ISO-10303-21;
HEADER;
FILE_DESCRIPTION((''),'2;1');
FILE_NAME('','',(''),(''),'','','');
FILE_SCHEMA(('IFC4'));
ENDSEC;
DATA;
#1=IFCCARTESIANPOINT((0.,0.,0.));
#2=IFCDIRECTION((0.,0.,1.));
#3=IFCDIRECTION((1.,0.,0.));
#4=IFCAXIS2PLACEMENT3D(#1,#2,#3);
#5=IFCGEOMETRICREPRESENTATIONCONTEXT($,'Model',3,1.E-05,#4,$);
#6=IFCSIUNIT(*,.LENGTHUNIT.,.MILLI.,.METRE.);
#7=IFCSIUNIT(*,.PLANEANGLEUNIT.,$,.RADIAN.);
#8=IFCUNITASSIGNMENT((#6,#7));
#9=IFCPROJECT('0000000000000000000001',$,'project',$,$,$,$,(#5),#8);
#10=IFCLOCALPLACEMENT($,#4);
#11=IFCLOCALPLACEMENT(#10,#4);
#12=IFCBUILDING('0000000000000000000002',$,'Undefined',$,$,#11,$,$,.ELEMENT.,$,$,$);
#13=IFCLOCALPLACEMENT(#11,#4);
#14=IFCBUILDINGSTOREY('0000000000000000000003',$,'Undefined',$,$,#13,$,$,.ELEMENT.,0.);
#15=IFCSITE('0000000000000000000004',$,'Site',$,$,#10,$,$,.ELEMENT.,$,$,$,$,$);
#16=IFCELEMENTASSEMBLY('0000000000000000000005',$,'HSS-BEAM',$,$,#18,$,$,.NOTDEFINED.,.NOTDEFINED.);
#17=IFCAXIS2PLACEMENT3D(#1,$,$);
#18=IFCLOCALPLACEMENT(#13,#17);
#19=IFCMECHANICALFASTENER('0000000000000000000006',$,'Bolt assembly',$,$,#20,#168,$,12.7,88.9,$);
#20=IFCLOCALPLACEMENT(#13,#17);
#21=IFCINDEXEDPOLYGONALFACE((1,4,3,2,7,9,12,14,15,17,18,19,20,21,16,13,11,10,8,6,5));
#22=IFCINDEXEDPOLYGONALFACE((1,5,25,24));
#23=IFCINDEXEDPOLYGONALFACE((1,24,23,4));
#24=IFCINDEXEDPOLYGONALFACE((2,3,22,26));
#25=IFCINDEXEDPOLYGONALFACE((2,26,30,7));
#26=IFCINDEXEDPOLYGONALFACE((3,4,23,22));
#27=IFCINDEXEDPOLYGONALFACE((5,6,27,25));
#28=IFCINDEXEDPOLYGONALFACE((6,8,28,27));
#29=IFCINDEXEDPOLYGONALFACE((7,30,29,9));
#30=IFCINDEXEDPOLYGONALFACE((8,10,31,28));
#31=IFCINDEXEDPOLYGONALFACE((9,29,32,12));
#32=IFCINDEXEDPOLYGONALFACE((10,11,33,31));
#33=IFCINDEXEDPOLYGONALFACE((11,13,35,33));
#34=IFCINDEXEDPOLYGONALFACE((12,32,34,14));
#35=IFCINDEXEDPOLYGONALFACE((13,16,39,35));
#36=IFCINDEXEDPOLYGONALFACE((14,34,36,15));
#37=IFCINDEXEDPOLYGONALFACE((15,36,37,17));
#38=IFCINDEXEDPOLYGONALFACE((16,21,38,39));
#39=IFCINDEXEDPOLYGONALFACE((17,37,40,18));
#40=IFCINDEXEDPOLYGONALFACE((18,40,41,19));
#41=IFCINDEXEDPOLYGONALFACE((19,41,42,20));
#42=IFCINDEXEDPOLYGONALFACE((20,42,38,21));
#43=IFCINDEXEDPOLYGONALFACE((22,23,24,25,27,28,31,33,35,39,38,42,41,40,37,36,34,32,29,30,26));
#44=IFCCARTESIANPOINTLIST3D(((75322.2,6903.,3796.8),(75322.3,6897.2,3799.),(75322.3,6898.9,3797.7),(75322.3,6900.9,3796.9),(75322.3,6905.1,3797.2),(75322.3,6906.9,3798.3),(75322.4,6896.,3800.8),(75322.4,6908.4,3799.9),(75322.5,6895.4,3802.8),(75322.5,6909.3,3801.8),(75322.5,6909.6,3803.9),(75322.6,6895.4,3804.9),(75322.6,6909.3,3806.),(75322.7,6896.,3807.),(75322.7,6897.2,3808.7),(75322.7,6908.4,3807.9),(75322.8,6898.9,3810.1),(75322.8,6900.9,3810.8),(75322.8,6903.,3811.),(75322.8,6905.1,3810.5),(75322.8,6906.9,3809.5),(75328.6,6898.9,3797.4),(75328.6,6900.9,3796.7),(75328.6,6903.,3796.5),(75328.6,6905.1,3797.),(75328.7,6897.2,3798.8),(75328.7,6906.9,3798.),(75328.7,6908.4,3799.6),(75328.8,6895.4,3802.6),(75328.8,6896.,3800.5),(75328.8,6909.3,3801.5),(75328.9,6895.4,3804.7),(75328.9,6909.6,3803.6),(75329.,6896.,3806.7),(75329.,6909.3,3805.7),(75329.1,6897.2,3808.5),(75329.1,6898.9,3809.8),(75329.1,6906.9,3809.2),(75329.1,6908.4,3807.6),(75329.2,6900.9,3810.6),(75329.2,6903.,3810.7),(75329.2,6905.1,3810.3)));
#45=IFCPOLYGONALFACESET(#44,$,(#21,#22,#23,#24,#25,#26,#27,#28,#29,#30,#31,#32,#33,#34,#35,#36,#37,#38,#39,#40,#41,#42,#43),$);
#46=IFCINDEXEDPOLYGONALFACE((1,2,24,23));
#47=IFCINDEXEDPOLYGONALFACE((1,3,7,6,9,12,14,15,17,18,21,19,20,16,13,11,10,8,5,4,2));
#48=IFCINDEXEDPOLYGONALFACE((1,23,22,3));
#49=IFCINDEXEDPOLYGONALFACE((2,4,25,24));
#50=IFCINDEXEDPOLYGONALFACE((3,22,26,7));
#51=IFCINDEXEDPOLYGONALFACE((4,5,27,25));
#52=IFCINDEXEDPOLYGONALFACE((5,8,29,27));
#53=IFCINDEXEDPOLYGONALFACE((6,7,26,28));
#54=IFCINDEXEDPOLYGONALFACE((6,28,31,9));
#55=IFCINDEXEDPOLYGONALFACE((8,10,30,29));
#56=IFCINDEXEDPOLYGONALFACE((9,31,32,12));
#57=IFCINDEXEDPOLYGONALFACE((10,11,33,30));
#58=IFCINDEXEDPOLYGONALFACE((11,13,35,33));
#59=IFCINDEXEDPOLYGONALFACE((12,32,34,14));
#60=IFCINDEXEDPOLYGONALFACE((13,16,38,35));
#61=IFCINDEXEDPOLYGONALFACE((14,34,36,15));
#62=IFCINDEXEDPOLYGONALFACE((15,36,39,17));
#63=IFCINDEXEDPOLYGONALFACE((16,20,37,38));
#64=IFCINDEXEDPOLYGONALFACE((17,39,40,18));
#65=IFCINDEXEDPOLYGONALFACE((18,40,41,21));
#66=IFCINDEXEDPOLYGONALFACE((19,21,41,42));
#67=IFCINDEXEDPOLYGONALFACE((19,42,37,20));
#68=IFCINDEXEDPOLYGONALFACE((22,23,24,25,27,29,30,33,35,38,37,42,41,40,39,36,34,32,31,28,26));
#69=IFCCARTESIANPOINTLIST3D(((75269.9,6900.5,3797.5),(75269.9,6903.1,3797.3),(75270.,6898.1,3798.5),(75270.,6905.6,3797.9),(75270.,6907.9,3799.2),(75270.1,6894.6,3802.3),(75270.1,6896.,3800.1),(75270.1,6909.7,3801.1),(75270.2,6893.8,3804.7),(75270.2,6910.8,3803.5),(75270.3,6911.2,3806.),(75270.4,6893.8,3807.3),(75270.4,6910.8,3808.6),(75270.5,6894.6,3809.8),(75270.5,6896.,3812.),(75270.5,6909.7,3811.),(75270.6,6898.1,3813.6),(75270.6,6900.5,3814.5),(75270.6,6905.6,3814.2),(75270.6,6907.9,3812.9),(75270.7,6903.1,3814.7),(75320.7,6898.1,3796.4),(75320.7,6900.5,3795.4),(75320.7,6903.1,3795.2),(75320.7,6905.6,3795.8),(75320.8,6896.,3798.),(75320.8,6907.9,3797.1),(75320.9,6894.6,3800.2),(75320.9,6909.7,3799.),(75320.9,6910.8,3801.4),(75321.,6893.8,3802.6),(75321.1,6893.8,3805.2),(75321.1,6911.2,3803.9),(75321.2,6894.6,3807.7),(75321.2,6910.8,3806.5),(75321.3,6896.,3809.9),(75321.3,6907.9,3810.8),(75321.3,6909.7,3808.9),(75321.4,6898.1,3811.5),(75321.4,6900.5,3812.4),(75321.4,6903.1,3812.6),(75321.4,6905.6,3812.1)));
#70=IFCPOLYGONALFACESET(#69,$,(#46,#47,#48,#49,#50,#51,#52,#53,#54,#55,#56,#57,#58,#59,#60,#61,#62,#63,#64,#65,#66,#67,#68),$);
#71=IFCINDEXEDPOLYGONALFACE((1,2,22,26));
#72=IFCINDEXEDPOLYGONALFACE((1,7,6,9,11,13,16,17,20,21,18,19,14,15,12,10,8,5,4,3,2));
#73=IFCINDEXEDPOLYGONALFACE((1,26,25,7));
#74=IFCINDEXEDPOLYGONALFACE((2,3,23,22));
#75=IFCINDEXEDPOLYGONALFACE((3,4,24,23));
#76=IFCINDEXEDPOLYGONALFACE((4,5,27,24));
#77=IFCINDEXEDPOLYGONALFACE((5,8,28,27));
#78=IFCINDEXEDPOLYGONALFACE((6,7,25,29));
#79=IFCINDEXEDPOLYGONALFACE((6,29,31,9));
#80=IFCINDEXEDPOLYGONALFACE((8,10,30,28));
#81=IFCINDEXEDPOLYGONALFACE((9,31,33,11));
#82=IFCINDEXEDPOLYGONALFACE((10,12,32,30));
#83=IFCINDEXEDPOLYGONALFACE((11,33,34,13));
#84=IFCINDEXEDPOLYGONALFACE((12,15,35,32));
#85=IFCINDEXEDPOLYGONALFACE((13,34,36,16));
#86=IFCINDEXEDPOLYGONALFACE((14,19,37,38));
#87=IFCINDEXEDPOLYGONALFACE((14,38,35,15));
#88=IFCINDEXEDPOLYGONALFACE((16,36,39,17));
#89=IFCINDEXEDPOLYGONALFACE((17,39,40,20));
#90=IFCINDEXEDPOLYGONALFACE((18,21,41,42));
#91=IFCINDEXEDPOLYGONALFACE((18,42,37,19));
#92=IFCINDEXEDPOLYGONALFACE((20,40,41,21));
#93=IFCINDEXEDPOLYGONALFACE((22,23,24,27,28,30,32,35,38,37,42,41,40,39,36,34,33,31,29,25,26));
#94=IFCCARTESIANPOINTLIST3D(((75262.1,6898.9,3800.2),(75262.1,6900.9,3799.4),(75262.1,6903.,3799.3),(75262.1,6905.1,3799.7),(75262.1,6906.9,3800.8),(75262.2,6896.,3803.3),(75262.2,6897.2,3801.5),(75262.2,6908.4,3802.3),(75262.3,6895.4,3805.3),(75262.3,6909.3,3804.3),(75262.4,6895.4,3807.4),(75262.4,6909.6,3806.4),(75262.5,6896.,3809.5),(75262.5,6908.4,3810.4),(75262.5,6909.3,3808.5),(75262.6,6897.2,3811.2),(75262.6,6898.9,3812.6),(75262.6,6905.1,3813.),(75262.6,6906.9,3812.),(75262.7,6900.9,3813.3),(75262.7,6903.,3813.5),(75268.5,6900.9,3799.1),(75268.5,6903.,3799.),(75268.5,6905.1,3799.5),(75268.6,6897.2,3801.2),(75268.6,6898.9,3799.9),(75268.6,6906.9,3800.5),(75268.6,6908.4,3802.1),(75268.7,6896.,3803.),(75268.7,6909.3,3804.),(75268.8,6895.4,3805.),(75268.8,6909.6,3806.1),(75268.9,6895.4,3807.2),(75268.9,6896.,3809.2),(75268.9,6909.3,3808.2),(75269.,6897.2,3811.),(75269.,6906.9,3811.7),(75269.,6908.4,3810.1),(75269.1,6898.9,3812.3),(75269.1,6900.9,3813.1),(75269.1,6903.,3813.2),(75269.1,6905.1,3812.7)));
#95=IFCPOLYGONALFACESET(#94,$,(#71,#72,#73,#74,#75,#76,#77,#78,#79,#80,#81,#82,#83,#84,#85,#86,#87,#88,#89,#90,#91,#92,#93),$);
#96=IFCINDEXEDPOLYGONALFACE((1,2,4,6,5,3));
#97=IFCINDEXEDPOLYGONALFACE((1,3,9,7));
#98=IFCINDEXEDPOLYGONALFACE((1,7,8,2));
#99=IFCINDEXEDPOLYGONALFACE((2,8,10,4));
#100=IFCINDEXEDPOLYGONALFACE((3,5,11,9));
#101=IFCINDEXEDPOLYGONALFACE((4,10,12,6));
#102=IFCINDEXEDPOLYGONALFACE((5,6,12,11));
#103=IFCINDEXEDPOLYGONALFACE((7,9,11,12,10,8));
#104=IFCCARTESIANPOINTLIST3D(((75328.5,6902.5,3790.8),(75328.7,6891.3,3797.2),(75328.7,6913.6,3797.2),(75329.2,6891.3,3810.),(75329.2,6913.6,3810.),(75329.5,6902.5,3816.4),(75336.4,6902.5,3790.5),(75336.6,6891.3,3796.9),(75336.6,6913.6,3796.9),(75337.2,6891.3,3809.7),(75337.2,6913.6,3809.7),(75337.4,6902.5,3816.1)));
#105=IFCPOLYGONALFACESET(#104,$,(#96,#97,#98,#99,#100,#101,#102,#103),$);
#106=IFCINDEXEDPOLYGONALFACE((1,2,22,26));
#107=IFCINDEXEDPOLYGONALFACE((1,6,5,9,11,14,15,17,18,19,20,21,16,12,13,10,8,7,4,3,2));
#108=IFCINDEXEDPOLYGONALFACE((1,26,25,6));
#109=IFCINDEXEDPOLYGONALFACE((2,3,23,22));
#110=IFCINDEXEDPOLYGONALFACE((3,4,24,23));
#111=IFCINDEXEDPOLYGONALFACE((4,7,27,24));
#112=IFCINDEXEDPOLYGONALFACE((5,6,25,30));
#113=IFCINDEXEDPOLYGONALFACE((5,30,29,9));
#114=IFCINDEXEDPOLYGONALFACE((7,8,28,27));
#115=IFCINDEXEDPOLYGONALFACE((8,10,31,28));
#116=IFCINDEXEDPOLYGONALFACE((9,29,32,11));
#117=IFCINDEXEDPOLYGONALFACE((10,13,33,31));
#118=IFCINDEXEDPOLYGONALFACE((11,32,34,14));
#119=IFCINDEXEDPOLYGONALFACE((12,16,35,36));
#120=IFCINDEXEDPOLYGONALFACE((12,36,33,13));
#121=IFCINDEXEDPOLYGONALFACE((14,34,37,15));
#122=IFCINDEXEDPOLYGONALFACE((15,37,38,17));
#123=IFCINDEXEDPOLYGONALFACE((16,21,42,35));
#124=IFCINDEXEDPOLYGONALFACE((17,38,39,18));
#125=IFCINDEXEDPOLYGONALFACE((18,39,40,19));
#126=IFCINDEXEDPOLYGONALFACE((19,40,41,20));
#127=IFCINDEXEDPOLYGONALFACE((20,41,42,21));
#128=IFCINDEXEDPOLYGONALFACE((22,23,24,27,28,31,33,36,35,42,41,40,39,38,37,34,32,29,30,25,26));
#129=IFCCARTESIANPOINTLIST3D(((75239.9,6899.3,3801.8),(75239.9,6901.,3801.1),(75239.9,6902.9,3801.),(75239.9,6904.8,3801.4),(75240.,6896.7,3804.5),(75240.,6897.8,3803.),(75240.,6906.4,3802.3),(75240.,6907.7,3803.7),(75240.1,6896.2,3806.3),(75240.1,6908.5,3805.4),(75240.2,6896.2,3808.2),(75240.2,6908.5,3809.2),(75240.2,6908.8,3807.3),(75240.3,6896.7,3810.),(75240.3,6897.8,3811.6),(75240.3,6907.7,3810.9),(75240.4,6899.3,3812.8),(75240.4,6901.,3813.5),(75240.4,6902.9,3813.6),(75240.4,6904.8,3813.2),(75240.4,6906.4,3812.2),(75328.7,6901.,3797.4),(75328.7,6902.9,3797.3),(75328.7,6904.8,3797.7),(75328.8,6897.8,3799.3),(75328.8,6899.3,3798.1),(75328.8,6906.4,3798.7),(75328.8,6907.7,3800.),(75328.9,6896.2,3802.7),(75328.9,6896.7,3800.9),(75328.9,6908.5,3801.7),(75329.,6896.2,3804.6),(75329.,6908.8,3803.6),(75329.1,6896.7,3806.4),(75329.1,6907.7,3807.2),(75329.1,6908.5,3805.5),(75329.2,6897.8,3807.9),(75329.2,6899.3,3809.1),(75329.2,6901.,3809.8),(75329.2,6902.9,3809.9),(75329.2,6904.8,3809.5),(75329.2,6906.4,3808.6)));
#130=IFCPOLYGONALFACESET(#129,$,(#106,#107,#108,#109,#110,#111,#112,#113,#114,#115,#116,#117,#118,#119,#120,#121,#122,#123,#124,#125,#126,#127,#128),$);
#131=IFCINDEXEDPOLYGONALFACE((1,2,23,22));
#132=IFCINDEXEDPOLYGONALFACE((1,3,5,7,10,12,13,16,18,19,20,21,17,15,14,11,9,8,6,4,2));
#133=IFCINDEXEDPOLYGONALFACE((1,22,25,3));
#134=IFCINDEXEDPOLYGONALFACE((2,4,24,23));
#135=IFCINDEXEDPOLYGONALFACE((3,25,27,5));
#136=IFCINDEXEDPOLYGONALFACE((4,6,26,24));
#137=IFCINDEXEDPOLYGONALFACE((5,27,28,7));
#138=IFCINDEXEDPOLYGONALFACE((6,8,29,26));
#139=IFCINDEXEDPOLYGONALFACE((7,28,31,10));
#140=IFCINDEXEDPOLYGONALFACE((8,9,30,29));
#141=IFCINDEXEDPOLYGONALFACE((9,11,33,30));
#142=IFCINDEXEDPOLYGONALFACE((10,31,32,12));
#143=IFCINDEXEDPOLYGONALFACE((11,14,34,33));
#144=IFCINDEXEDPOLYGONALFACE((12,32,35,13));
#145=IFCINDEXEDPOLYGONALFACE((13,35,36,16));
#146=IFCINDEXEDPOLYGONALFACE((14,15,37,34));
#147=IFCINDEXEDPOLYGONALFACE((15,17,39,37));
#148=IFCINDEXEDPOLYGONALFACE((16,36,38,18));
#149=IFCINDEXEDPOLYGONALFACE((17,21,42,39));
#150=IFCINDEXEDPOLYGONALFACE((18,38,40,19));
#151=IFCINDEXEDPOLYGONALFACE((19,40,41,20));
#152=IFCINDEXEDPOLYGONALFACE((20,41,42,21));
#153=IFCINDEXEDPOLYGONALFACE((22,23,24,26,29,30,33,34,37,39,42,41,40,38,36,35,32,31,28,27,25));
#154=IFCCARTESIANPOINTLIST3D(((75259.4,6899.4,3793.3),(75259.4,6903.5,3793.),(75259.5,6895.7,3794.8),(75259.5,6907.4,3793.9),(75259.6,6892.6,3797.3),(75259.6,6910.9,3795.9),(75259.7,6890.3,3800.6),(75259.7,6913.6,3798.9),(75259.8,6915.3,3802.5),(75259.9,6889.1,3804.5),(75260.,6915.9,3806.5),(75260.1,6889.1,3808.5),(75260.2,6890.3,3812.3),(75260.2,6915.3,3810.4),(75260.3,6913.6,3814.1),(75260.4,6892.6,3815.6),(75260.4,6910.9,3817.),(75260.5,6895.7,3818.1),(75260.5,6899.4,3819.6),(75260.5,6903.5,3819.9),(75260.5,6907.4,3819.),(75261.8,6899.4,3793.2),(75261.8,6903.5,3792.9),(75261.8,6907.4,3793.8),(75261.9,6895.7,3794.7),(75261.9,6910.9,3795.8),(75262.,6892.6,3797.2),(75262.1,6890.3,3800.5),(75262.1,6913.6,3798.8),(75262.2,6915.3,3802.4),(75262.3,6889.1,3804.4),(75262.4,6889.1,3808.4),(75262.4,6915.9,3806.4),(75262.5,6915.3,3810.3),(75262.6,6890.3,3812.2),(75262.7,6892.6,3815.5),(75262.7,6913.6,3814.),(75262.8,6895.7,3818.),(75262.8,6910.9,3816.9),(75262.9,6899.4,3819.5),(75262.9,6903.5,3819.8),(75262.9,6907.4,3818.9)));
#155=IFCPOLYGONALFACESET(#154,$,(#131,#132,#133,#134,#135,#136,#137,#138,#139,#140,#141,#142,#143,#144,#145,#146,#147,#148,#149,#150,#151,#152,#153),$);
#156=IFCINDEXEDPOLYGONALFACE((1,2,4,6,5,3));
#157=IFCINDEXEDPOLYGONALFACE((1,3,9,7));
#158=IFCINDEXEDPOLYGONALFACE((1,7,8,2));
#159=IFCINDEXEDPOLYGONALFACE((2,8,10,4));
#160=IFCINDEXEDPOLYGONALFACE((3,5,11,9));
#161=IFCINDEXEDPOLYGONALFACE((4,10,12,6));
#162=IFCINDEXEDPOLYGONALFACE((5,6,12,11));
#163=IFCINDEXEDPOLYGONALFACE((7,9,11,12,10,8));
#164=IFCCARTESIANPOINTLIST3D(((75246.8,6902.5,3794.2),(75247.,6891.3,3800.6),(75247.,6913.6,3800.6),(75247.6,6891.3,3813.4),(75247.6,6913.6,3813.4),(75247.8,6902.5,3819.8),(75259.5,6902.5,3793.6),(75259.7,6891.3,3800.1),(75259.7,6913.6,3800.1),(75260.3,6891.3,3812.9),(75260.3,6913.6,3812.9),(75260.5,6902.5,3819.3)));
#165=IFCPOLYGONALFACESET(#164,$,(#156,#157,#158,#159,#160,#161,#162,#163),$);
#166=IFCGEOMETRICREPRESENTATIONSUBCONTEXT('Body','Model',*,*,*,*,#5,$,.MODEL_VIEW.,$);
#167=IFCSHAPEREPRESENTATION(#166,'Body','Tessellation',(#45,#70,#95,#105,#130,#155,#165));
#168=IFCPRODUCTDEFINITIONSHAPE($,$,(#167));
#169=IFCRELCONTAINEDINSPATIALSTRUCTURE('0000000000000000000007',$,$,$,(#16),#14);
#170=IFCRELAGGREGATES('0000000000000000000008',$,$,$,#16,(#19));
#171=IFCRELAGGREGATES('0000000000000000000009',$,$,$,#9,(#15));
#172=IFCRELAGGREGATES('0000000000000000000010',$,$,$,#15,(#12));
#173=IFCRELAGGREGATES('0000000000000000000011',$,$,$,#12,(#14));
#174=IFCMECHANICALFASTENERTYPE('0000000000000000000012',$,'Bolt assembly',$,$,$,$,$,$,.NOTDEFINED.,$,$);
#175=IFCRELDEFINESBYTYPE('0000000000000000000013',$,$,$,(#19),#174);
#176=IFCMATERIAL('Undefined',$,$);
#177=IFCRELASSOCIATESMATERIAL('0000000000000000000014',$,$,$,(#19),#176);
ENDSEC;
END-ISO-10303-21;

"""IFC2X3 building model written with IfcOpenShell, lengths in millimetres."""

from ifc_helpers import new_model, si_unit, frame, origin_with_axes, origin_2d_with_axis, place, context, subcontext, project, spatial, polyline, circle, outline, extrude, source, transform, mapped, material, type_object, element, aggregate, save


model = new_model("IFC2X3")

# Units and contexts
model_context = context("Model", 3, precision=1e-05, world=origin_with_axes())
body_context = subcontext(model_context, "Body", "Model", "MODEL_VIEW")
ifc_project = project(units=[si_unit("LENGTHUNIT", "METRE", prefix="MILLI"), si_unit("PLANEANGLEUNIT", "RADIAN")], contexts=[model_context])

# Site, building, storey
site_placement = place(None, origin_with_axes())
site = spatial("IfcSite", under=ifc_project, at=site_placement, Name="Site", CompositionType="ELEMENT")
building_placement = place(site_placement, origin_with_axes())
building = spatial("IfcBuilding", under=site, at=building_placement, Name="Undefined", CompositionType="ELEMENT")
storey_placement = place(building_placement, origin_with_axes())
storey = spatial("IfcBuildingStorey", under=building, at=storey_placement, Name="Undefined", CompositionType="ELEMENT", Elevation=0.0)

# Shared definitions
ifc_material_1 = material(Name="Undefined")
mechanical_fastener_type = type_object("IfcMechanicalFastenerType", Name="Bolt assembly")

# Shared definitions
shared_shape_1 = source(origin_with_axes(), body_context, "Body", "SweptSolid", [
    extrude(circle(Radius=7.1, at=origin_2d_with_axis()), frame((0.0, -33.2, 0.0), z_axis=(0.0, 1.0, 0.0), x_axis=(1.0, 0.0, 0.0)), (0.0, 0.0, 1.0), 6.3),
    extrude(circle(Radius=8.7, at=origin_2d_with_axis()), frame((0.0, -25.4, 0.0), z_axis=(0.0, 1.0, 0.0), x_axis=(1.0, 0.0, 0.0)), (0.0, 0.0, 1.0), 50.8),
    extrude(circle(Radius=7.1, at=origin_2d_with_axis()), frame((0.0, 26.9, 0.0), z_axis=(0.0, 1.0, 0.0), x_axis=(1.0, 0.0, 0.0)), (0.0, 0.0, 1.0), 6.5),
    extrude(outline(polyline([(11.1, -6.4), (11.1, 6.4), (0.0, 12.8), (-11.1, 6.4), (-11.1, -6.4), (0.0, -12.8), (11.1, -6.4)])), frame((0.0, -41.3, 0.0), z_axis=(0.0, 1.0, 0.0), x_axis=(1.0, 0.0, 0.0)), (0.0, 0.0, 1.0), 7.9),
    extrude(circle(Radius=6.3, at=origin_2d_with_axis()), frame((0.0, -33.3, 0.0), z_axis=(0.0, 1.0, 0.0), x_axis=(1.0, 0.0, 0.0)), (0.0, 0.0, 1.0), 88.9),
    extrude(circle(Radius=13.5, at=origin_2d_with_axis()), frame((0.0, 33.3, 0.0), z_axis=(0.0, 1.0, 0.0), x_axis=(1.0, 0.0, 0.0)), (0.0, 0.0, 1.0), 2.4),
    extrude(outline(polyline([(11.1, -6.4), (11.1, 6.4), (0.0, 12.8), (-11.1, 6.4), (-11.1, -6.4), (0.0, -12.8), (11.1, -6.4)])), frame((0.0, 35.7, 0.0), z_axis=(0.0, 1.0, 0.0), x_axis=(1.0, 0.0, 0.0)), (0.0, 0.0, 1.0), 12.7),
])

# Element assembly, mechanical fastener
assembly_1_placement = place(storey_placement, origin_with_axes())
assembly_1 = element("IfcElementAssembly", 1, at=assembly_1_placement, inside=storey, Name="HSS-BEAM", AssemblyPlace="NOTDEFINED", PredefinedType="NOTDEFINED")
mechanical_fastener_1_placement = place(assembly_1_placement, frame((75295.7, 6902.5, 3805.0), z_axis=(0.041337, 0.0, 0.999145), x_axis=(0.0, 1.0, 0.0)))
mechanical_fastener_1 = element("IfcMechanicalFastener", 2, at=mechanical_fastener_1_placement, type_object=mechanical_fastener_type, material=ifc_material_1, Name="Bolt assembly", NominalDiameter=12.7, NominalLength=88.9, context=body_context, shape_type="MappedRepresentation", body=[
    mapped(shared_shape_1, transform((0.0, 0.0, 0.0))),
])
aggregate(assembly_1, [mechanical_fastener_1])

save(model, "model.ifc")
